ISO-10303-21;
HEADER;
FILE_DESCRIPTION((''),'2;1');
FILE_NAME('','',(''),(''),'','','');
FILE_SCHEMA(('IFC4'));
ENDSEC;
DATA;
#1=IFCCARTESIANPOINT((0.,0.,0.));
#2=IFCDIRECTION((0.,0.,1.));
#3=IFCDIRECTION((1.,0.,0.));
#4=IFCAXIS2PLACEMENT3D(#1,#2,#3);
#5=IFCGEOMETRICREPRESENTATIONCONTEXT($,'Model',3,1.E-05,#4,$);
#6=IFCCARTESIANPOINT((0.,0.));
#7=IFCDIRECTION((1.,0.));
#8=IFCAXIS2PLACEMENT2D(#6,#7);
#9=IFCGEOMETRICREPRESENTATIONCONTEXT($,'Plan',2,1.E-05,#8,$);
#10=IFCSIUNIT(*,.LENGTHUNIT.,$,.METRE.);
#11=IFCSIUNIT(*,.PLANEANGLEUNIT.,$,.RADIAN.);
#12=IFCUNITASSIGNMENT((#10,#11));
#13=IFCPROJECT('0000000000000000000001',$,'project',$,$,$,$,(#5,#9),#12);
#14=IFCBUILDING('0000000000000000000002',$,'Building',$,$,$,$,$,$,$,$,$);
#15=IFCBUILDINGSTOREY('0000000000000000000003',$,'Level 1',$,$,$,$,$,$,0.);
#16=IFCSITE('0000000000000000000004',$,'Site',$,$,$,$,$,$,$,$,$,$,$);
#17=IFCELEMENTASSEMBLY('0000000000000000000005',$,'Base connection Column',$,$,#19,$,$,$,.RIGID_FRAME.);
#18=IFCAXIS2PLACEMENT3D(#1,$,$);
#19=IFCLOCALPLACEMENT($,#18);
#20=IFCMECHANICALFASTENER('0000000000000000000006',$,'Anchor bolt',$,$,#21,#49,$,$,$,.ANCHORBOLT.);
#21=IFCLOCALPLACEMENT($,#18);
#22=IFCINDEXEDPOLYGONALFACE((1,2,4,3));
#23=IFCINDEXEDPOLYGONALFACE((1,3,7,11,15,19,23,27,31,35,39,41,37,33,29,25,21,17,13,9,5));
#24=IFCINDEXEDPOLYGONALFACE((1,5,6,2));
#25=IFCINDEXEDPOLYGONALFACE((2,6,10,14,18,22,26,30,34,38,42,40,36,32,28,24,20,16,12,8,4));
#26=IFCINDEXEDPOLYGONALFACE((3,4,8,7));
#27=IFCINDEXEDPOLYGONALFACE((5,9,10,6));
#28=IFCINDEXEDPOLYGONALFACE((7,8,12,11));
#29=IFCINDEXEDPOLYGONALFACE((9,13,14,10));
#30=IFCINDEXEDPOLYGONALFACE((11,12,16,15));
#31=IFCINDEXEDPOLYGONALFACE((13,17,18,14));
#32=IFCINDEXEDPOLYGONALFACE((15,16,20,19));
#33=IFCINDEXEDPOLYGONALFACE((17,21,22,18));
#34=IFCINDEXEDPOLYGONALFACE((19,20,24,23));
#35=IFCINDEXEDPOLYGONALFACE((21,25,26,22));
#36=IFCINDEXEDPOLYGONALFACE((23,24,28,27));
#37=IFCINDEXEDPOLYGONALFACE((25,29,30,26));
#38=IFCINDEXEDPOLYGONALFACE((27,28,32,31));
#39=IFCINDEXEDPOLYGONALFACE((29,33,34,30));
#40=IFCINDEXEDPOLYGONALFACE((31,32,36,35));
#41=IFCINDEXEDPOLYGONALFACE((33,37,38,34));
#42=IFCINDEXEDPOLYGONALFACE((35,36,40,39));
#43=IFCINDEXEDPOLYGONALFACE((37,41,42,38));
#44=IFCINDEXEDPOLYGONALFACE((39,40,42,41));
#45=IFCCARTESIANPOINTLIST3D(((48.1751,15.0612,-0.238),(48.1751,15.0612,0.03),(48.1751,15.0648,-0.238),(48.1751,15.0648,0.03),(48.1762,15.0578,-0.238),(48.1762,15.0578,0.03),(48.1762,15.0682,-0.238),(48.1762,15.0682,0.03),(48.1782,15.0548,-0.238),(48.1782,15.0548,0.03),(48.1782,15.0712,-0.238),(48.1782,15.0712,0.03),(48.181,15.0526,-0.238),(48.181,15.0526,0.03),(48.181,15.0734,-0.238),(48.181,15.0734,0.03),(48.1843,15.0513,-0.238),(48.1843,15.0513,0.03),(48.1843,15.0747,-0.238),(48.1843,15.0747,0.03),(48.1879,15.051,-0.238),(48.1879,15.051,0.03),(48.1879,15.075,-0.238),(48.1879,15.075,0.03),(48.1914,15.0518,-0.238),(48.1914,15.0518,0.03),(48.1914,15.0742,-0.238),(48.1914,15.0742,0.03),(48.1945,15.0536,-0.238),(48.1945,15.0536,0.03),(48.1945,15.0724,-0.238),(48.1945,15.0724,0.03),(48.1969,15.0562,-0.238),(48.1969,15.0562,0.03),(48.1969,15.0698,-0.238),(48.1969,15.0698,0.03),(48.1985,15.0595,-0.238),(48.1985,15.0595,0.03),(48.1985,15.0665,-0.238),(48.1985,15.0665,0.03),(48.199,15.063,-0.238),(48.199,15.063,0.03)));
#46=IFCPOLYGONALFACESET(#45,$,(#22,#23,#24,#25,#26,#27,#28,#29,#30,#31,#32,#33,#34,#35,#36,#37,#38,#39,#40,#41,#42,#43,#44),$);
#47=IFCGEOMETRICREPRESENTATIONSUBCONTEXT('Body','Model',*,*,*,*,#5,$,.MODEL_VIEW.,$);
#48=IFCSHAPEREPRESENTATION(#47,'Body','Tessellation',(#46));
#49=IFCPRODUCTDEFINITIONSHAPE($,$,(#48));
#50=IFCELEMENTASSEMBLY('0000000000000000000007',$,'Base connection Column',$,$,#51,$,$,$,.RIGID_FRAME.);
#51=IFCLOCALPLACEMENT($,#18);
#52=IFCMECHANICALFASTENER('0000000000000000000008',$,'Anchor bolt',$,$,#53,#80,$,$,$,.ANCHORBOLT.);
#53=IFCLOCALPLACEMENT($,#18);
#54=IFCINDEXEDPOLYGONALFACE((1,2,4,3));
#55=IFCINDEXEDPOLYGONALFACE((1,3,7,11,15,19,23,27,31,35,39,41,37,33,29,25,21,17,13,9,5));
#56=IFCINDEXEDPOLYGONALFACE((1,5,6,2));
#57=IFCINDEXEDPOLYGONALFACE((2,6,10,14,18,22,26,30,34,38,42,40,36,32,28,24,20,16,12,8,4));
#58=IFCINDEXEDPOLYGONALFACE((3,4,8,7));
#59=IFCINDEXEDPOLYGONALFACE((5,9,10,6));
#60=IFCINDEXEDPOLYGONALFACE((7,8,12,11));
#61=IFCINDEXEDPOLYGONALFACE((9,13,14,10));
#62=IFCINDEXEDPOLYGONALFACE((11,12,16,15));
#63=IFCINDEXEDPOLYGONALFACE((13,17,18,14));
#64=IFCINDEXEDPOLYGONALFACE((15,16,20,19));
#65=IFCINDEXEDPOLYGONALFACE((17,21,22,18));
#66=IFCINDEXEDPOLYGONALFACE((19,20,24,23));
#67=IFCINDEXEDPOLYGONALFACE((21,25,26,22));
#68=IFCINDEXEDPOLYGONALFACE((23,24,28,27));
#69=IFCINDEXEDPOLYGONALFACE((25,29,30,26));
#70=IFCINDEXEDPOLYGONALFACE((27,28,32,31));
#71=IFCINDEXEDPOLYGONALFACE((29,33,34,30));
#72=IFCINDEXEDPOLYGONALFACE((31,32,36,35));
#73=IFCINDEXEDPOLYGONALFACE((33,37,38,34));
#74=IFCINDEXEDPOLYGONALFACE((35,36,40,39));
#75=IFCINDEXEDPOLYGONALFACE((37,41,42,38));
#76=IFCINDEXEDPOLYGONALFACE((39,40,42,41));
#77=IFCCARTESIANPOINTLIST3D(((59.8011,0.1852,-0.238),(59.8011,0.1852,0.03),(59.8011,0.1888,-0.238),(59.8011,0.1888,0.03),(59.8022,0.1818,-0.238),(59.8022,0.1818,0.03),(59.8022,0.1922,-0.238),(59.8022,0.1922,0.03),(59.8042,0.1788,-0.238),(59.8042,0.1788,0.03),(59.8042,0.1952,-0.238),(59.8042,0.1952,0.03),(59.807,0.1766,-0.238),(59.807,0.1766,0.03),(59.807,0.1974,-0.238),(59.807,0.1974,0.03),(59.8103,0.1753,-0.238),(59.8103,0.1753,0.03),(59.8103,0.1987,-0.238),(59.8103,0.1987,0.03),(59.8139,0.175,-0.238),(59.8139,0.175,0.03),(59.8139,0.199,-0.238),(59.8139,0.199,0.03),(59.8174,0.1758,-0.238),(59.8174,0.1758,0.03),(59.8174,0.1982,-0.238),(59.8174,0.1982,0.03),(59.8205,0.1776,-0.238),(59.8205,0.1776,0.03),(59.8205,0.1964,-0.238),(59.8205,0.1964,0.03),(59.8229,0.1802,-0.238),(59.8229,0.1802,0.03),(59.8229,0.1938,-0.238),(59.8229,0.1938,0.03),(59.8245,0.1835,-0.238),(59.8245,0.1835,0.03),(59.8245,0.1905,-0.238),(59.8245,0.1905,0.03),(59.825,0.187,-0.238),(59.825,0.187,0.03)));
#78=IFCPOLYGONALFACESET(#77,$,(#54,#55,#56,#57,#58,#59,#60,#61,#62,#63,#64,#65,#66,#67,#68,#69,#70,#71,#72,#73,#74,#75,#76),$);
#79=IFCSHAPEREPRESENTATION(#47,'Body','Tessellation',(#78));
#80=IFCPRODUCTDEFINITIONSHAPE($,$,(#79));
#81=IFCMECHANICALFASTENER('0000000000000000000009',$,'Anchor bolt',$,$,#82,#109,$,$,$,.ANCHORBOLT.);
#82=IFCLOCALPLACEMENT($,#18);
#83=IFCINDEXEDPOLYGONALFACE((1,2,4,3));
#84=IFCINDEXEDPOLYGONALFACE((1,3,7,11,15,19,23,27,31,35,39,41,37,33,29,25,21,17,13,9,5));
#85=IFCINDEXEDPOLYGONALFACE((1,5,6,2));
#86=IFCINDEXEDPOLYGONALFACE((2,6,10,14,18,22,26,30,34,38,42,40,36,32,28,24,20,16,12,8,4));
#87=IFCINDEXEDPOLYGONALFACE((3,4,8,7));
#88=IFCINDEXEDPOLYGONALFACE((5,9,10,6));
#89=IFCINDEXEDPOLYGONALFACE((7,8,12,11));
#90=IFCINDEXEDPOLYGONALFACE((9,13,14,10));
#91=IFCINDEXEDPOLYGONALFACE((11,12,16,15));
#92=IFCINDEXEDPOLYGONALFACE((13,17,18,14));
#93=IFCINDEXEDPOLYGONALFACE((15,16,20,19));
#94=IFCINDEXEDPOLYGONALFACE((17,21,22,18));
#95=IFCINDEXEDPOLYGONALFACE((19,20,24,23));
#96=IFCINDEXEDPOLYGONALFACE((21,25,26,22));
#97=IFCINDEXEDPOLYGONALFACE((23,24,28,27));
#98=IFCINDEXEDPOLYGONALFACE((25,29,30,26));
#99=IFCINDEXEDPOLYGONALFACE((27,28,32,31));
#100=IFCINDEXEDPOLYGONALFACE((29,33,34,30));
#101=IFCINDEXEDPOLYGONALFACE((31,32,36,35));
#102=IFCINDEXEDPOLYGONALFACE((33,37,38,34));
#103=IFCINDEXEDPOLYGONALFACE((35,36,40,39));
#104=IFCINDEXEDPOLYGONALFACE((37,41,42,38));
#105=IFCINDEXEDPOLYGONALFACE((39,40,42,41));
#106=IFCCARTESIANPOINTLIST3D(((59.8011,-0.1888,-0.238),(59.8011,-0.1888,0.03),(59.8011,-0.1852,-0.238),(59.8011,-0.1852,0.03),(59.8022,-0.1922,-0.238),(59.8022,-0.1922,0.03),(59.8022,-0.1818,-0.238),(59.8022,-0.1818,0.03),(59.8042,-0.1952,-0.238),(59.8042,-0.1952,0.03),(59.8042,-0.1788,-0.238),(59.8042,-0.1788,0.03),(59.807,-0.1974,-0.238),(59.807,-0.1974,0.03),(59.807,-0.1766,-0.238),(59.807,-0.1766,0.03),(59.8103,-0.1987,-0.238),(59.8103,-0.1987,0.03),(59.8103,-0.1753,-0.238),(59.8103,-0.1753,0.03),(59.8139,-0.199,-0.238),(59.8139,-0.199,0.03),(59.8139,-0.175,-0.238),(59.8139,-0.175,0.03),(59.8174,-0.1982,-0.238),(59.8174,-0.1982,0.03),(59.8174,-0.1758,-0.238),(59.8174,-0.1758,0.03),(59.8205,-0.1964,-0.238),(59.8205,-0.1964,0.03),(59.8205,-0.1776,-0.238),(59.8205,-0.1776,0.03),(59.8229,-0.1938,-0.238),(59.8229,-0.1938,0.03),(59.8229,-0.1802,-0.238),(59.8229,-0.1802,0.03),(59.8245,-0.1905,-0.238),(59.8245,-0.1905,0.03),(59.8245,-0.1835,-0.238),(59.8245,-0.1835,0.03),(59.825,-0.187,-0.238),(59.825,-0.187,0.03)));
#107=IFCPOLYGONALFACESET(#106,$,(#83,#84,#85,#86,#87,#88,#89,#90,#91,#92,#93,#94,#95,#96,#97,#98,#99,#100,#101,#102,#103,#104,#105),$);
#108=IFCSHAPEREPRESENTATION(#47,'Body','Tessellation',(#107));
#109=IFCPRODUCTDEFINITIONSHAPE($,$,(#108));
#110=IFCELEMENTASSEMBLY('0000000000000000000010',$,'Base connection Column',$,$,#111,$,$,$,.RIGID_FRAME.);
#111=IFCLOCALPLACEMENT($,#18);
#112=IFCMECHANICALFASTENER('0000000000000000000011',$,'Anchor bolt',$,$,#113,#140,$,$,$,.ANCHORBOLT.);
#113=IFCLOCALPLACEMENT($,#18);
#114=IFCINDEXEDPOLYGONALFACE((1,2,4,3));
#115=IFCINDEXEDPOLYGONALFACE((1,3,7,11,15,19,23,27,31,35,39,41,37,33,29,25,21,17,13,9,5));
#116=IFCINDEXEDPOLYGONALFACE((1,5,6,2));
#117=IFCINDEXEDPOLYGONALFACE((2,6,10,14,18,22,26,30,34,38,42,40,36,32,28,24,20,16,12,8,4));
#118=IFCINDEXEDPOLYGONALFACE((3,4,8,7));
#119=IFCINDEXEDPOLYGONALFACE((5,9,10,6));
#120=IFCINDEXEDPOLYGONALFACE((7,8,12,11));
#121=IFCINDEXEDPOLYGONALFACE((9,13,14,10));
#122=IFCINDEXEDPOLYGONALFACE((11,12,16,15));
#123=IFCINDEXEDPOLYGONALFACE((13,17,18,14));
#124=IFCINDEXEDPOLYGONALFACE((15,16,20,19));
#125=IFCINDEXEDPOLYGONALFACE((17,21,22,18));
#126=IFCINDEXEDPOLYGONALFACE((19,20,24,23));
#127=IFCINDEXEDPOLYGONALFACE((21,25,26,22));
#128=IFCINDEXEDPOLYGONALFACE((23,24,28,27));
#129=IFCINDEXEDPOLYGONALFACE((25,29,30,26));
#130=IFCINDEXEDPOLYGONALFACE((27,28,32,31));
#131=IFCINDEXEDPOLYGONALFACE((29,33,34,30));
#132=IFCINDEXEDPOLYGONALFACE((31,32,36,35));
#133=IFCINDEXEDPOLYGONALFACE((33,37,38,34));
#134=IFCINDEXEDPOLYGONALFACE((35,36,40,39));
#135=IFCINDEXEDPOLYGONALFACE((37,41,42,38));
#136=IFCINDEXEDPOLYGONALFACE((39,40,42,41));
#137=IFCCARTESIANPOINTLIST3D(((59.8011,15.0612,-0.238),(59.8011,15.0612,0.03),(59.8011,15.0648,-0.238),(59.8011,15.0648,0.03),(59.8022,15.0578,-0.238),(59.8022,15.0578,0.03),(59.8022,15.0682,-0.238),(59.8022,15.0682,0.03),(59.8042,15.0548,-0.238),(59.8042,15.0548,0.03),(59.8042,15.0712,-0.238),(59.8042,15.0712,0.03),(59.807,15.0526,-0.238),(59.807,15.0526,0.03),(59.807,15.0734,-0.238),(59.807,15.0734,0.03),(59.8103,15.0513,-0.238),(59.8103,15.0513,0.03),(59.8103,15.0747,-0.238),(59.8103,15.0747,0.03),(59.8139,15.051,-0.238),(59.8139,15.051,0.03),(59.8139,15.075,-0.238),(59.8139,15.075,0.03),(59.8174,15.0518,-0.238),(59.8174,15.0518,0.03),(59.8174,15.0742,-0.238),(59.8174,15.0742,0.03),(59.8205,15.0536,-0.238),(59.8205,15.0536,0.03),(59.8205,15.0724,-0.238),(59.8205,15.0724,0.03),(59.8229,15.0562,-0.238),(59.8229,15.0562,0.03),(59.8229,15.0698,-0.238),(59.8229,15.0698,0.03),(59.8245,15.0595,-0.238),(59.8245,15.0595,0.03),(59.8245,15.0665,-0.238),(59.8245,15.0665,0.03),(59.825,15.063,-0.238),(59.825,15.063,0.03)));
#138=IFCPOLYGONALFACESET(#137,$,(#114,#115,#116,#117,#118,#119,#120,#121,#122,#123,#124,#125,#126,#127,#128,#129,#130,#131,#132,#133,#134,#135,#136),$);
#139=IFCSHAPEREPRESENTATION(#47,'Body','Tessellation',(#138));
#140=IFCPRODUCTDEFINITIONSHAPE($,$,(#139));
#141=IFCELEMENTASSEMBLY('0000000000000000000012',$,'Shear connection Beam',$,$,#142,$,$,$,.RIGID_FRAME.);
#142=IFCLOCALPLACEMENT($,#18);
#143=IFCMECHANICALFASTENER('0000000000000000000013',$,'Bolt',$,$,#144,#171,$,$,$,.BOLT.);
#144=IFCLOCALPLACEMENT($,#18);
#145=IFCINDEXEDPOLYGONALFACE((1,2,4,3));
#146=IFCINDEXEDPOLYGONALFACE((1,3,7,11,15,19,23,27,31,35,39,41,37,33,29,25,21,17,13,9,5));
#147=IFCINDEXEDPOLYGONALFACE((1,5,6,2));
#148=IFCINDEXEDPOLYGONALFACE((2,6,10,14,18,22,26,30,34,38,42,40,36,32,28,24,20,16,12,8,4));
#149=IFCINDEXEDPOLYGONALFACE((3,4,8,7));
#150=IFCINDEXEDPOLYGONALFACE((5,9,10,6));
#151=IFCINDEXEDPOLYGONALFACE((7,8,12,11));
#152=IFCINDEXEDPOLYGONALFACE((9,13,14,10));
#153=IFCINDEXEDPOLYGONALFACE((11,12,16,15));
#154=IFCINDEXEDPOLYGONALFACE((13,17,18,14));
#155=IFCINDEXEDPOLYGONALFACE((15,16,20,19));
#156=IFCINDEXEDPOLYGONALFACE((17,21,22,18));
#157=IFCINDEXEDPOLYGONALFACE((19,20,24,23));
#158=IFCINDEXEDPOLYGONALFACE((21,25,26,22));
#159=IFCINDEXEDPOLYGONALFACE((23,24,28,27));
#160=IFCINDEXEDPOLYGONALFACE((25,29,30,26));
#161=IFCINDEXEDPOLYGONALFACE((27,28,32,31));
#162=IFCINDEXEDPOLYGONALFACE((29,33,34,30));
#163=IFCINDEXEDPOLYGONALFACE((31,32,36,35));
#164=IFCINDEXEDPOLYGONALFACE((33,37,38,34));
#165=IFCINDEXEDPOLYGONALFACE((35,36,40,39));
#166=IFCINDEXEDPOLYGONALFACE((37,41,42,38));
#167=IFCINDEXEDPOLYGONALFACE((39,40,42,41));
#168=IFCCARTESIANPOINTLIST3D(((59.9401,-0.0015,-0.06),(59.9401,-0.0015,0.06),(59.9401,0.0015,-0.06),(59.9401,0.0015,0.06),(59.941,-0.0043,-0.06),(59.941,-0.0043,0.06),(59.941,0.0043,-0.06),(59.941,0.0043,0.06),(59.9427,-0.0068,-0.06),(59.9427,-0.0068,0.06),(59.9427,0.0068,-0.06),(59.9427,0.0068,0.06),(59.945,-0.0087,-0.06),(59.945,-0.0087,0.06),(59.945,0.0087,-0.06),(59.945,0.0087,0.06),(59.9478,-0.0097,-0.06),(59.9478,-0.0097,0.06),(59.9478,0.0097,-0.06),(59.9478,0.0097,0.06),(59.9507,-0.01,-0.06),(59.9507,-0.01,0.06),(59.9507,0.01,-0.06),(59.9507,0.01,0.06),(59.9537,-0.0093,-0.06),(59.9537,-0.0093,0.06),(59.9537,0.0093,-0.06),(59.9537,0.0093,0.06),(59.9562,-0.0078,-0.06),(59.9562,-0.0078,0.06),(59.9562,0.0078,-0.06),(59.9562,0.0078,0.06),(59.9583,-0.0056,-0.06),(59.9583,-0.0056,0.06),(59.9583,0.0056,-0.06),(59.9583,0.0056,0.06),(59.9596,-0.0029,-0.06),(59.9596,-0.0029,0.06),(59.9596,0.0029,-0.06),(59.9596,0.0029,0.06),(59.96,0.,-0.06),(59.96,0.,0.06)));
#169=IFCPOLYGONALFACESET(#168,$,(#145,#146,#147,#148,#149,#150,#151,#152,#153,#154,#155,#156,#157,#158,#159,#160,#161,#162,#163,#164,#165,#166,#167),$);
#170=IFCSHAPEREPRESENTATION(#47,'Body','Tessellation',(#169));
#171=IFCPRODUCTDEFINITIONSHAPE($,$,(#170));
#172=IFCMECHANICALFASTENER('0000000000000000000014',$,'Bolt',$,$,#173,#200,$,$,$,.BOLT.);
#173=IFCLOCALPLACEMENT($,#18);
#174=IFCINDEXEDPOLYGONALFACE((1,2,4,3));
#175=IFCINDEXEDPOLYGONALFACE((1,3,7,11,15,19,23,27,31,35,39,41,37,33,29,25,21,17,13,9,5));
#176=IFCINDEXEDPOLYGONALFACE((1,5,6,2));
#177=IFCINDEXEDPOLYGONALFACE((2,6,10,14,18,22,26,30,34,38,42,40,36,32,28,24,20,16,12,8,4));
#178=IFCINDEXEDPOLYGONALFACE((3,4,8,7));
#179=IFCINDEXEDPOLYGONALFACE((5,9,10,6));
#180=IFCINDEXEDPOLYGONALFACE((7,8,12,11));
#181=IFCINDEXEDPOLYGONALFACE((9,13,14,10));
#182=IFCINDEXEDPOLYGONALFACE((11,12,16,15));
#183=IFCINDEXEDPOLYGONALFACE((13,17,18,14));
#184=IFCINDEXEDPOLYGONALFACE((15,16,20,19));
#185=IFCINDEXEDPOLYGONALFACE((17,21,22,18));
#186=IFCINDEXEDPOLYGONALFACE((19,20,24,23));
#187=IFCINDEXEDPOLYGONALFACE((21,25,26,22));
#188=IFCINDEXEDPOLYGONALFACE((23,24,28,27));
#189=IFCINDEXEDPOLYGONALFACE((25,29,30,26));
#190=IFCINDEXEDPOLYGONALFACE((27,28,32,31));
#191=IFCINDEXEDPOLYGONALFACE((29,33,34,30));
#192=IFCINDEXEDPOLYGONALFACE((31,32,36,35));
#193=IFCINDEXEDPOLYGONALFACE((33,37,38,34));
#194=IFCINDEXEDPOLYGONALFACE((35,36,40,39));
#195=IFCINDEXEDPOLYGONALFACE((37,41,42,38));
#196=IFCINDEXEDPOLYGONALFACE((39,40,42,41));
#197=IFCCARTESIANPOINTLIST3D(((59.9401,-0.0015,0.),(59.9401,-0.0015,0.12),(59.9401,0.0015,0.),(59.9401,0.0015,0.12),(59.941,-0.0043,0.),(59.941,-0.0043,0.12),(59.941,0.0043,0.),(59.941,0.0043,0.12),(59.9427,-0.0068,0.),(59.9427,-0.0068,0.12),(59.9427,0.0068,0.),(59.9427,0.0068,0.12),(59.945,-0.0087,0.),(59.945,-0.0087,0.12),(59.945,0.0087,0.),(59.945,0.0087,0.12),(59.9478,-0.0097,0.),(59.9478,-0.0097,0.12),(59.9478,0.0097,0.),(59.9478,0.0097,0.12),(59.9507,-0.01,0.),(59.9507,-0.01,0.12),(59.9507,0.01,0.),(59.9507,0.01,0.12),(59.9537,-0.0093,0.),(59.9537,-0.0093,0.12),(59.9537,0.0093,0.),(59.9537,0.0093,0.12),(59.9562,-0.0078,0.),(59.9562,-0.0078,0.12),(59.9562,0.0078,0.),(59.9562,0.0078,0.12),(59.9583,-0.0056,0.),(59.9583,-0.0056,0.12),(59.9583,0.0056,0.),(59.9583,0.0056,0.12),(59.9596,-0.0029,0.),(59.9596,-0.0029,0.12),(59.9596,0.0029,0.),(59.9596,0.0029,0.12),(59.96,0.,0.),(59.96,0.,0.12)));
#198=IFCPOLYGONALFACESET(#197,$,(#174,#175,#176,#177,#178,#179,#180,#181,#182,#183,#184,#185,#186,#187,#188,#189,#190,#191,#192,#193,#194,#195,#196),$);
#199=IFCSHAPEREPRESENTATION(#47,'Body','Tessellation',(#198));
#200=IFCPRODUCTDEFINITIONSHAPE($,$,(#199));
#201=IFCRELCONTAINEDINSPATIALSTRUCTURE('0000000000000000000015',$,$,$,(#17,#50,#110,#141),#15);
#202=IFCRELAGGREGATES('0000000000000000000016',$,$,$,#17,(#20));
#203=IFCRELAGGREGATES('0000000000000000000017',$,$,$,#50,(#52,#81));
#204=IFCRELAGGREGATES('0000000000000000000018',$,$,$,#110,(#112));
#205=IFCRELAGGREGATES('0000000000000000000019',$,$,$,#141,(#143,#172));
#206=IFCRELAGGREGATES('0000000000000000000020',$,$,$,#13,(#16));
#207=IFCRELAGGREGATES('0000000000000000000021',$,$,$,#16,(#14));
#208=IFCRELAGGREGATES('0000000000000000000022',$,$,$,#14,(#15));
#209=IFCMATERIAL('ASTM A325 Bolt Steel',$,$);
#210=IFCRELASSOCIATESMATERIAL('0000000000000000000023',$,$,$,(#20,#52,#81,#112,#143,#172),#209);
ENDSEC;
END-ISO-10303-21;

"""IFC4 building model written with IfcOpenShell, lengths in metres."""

from ifc_helpers import new_model, si_unit, frame, origin_with_axes, origin_2d, origin_2d_with_axis, place, context, subcontext, project, spatial, circle, extrude, material, element, aggregate, save


model = new_model("IFC4")

# Units and contexts
model_context = context("Model", 3, precision=1e-05, world=origin_with_axes())
plan_context = context("Plan", 2, precision=1e-05, world=origin_2d_with_axis())
body_context = subcontext(model_context, "Body", "Model", "MODEL_VIEW")
ifc_project = project(units=[si_unit("LENGTHUNIT", "METRE"), si_unit("PLANEANGLEUNIT", "RADIAN")], contexts=[model_context, plan_context])

# Site, building, storey
site = spatial("IfcSite", under=ifc_project, Name="Site")
building = spatial("IfcBuilding", under=site, Name="Building")
storey = spatial("IfcBuildingStorey", under=building, Name="Level 1", Elevation=0.0)

# Shared definitions
ifc_material_1 = material(Name="ASTM A325 Bolt Steel")

# Element assembly, mechanical fastener
assembly_1 = element("IfcElementAssembly", 1, inside=storey, Name="Base connection Column", PredefinedType="RIGID_FRAME")
mechanical_fastener_1_placement = place(None, frame((48.187, 15.063, -0.238), z_axis=(0.0, 0.0, 1.0), x_axis=(1.0, 0.0, 0.0)))
mechanical_fastener_1 = element("IfcMechanicalFastener", 2, at=mechanical_fastener_1_placement, material=ifc_material_1, Name="Anchor bolt", PredefinedType="ANCHORBOLT", context=body_context, shape_type="SweptSolid", body=[
    extrude(circle(Radius=0.012, at=origin_2d()), origin_with_axes(), (0.0, 0.0, 1.0), 0.268),
])
aggregate(assembly_1, [mechanical_fastener_1])

# Element assembly, mechanical fasteners
assembly_2 = element("IfcElementAssembly", 3, inside=storey, Name="Base connection Column", PredefinedType="RIGID_FRAME")
mechanical_fastener_2_placement = place(None, frame((59.813, 0.187, -0.238), z_axis=(0.0, 0.0, 1.0), x_axis=(1.0, 0.0, 0.0)))
mechanical_fastener_2 = element("IfcMechanicalFastener", 4, at=mechanical_fastener_2_placement, material=ifc_material_1, Name="Anchor bolt", PredefinedType="ANCHORBOLT", context=body_context, shape_type="SweptSolid", body=[
    extrude(circle(Radius=0.012, at=origin_2d()), origin_with_axes(), (0.0, 0.0, 1.0), 0.268),
])
mechanical_fastener_3_placement = place(None, frame((59.813, -0.187, -0.238), z_axis=(0.0, 0.0, 1.0), x_axis=(1.0, 0.0, 0.0)))
mechanical_fastener_3 = element("IfcMechanicalFastener", 5, at=mechanical_fastener_3_placement, material=ifc_material_1, Name="Anchor bolt", PredefinedType="ANCHORBOLT", context=body_context, shape_type="SweptSolid", body=[
    extrude(circle(Radius=0.012, at=origin_2d()), origin_with_axes(), (0.0, 0.0, 1.0), 0.268),
])
aggregate(assembly_2, [mechanical_fastener_2, mechanical_fastener_3])

# Element assembly, mechanical fastener
assembly_3 = element("IfcElementAssembly", 6, inside=storey, Name="Base connection Column", PredefinedType="RIGID_FRAME")
mechanical_fastener_4_placement = place(None, frame((59.813, 15.063, -0.238), z_axis=(0.0, 0.0, 1.0), x_axis=(1.0, 0.0, 0.0)))
mechanical_fastener_4 = element("IfcMechanicalFastener", 7, at=mechanical_fastener_4_placement, material=ifc_material_1, Name="Anchor bolt", PredefinedType="ANCHORBOLT", context=body_context, shape_type="SweptSolid", body=[
    extrude(circle(Radius=0.012, at=origin_2d()), origin_with_axes(), (0.0, 0.0, 1.0), 0.268),
])
aggregate(assembly_3, [mechanical_fastener_4])

# Element assembly, mechanical fasteners
assembly_4 = element("IfcElementAssembly", 8, inside=storey, Name="Shear connection Beam", PredefinedType="RIGID_FRAME")
mechanical_fastener_5_placement = place(None, frame((59.95, 0.0, -0.06), z_axis=(0.0, 0.0, 1.0), x_axis=(1.0, 0.0, 0.0)))
mechanical_fastener_5 = element("IfcMechanicalFastener", 9, at=mechanical_fastener_5_placement, material=ifc_material_1, Name="Bolt", PredefinedType="BOLT", context=body_context, shape_type="SweptSolid", body=[
    extrude(circle(Radius=0.01, at=origin_2d()), origin_with_axes(), (0.0, 0.0, 1.0), 0.12),
])
mechanical_fastener_6_placement = place(None, frame((59.95, 0.0, 0.0), z_axis=(0.0, 0.0, 1.0), x_axis=(1.0, 0.0, 0.0)))
mechanical_fastener_6 = element("IfcMechanicalFastener", 10, at=mechanical_fastener_6_placement, material=ifc_material_1, Name="Bolt", PredefinedType="BOLT", context=body_context, shape_type="SweptSolid", body=[
    extrude(circle(Radius=0.01, at=origin_2d()), origin_with_axes(), (0.0, 0.0, 1.0), 0.12),
])
aggregate(assembly_4, [mechanical_fastener_5, mechanical_fastener_6])

save(model, "model.ifc")
